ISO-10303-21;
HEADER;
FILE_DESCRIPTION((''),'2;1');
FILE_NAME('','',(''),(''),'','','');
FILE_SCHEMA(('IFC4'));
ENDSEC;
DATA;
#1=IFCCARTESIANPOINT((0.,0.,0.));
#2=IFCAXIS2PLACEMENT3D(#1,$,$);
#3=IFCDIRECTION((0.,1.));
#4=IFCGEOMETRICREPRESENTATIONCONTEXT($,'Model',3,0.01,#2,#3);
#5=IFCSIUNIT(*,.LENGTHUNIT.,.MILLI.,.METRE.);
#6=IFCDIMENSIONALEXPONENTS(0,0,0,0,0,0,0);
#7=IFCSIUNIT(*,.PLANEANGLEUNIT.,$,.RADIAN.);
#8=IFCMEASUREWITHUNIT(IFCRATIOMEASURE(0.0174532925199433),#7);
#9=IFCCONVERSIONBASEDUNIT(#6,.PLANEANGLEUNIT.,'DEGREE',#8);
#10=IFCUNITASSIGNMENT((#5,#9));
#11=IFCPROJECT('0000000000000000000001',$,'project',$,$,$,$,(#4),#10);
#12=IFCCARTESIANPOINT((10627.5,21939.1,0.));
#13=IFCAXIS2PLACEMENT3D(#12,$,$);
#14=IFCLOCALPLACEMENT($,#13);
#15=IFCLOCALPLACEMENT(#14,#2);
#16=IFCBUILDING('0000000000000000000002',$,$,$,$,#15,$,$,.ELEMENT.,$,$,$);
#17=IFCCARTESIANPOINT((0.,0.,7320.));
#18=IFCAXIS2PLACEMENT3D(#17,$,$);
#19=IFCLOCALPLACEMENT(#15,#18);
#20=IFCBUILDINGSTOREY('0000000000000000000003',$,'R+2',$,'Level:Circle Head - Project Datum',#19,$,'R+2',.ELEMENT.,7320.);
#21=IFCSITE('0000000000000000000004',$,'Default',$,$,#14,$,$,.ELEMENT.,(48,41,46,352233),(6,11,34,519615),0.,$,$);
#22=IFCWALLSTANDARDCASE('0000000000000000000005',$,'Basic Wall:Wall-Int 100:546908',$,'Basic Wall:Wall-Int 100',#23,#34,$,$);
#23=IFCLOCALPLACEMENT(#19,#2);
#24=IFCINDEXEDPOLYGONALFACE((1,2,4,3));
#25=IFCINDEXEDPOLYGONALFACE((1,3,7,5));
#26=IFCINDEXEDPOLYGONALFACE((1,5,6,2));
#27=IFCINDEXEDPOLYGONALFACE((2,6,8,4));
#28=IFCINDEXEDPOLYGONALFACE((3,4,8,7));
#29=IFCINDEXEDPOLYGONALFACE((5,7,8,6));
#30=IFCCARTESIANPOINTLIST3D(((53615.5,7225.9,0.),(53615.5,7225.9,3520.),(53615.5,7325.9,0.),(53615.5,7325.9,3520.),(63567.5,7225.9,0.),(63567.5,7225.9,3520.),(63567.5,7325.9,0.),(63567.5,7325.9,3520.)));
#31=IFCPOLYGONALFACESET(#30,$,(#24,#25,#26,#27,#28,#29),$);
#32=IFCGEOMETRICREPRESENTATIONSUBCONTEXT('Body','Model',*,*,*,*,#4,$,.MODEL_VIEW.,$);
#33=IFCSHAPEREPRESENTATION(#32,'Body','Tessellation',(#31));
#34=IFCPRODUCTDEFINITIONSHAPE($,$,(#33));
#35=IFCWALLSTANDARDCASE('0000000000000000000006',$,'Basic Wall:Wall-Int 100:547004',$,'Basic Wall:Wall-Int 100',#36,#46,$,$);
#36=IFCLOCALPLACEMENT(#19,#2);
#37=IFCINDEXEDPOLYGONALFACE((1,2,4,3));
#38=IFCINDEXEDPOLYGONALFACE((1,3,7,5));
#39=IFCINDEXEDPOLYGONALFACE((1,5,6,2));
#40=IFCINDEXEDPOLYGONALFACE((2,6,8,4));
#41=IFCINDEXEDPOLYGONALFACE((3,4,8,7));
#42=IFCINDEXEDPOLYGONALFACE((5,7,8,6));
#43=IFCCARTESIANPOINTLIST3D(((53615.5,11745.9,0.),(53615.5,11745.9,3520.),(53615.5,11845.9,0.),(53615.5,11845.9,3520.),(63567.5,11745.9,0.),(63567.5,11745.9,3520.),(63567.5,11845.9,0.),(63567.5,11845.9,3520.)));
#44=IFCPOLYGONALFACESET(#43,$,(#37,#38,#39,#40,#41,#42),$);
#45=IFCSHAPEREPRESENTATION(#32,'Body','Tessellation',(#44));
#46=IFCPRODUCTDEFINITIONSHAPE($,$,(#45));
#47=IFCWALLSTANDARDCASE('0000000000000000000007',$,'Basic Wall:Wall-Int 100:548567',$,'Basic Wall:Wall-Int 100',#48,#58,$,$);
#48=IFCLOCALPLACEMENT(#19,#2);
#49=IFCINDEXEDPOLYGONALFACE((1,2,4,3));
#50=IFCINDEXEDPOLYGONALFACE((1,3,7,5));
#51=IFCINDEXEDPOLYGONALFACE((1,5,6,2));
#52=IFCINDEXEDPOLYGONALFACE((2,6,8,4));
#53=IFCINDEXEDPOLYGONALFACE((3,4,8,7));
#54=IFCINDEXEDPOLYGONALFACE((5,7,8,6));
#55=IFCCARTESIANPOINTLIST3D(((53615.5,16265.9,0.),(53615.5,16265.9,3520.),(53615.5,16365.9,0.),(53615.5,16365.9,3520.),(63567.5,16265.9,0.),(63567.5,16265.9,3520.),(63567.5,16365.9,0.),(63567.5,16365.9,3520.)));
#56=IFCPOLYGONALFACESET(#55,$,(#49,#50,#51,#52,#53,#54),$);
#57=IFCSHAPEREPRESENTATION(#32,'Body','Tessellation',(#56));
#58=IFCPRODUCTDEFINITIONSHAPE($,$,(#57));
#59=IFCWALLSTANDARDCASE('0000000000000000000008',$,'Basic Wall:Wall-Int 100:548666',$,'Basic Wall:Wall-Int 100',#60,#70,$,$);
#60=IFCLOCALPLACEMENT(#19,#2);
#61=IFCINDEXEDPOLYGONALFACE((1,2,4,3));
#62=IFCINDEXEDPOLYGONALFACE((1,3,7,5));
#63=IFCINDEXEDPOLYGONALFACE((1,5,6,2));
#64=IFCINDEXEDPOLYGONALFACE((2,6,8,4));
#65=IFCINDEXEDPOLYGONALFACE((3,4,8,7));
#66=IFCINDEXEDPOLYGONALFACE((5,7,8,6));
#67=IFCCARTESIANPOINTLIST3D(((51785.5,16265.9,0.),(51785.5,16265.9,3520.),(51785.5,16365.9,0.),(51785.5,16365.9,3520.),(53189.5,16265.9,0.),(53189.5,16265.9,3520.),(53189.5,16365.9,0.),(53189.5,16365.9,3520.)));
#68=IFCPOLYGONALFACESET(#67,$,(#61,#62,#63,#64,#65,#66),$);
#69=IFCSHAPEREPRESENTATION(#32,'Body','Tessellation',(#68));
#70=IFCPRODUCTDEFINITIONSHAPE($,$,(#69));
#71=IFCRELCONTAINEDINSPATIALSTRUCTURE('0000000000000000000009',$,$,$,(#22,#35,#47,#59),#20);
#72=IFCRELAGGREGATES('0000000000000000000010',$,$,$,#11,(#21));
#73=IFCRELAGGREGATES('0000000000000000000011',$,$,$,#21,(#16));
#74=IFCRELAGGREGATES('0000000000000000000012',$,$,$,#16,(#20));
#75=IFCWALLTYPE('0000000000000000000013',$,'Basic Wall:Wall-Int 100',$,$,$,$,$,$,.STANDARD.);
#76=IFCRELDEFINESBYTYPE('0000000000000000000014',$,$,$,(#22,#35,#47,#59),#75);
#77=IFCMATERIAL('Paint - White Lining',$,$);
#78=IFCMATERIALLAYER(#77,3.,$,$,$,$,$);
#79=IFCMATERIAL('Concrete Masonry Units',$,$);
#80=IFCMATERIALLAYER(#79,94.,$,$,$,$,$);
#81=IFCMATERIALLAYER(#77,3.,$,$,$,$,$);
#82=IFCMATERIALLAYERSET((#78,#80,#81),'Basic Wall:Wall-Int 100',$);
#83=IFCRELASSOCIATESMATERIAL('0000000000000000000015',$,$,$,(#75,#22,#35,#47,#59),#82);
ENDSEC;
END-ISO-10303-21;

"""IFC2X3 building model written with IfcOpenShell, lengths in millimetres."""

from ifc_helpers import new_model, entity, si_unit, converted_unit, direction, frame, frame_2d, origin, place, context, subcontext, project, spatial, rectangle, extrude, material, layer, layer_set, layer_usage, type_object, element, save


model = new_model("IFC2X3")

# Units and contexts
model_context = context("Model", 3, precision=0.01, world=origin(), true_north=direction((0.0, 1.0)))
body_context = subcontext(model_context, "Body", "Model", "MODEL_VIEW")
ifc_project = project(units=[si_unit("LENGTHUNIT", "METRE", prefix="MILLI"), converted_unit("PLANEANGLEUNIT", "DEGREE", entity("IfcRatioMeasure", 0.0174532925199433), si_unit("PLANEANGLEUNIT", "RADIAN"), dimensions=[0, 0, 0, 0, 0, 0, 0])], contexts=[model_context])

# Site, building, storey
site_placement = place(None, frame((10627.5, 21939.1, 0.0)))
site = spatial("IfcSite", under=ifc_project, at=site_placement, Name="Default", CompositionType="ELEMENT", RefLatitude=(48, 41, 46, 352233), RefLongitude=(6, 11, 34, 519615), RefElevation=0.0)
building_placement = place(site_placement, origin())
building = spatial("IfcBuilding", under=site, at=building_placement, CompositionType="ELEMENT")
storey_placement = place(building_placement, frame((0.0, 0.0, 7320.0)))
storey = spatial("IfcBuildingStorey", under=building, at=storey_placement, Name="R+2", ObjectType="Level:Circle Head - Project Datum", LongName="R+2", CompositionType="ELEMENT", Elevation=7320.0)

# Walls
ifc_material_1 = material(Name="Paint - White Lining")
ifc_layer_1 = layer(ifc_material_1, 3.0)
ifc_material_2 = material(Name="Concrete Masonry Units")
ifc_layer_2 = layer(ifc_material_2, 94.0)
ifc_layer_3 = layer(ifc_material_1, 3.0)
ifc_layer_set = layer_set([ifc_layer_1, ifc_layer_2, ifc_layer_3], Name="Basic Wall:Wall-Int 100")
ifc_layer_usage_1 = layer_usage(ifc_layer_set, "AXIS2", "NEGATIVE", 50.0)
wall_type = type_object("IfcWallType", Name="Basic Wall:Wall-Int 100", PredefinedType="STANDARD", material=ifc_layer_set)
wall_1_placement = place(storey_placement, frame((63567.5, 7275.9, 0.0), z_axis=(0.0, 0.0, 1.0), x_axis=(-1.0, 0.0, 0.0)))
element("IfcWallStandardCase", 1, at=wall_1_placement, inside=storey, type_object=wall_type, material=ifc_layer_usage_1, Name="Basic Wall:Wall-Int 100:546908", ObjectType="Basic Wall:Wall-Int 100", context=body_context, shape_type="SweptSolid", body=[
    extrude(rectangle(XDim=9952.0, YDim=100.0, at=frame_2d((4976.0, 0.0), x_axis=(-1.0, 0.0))), origin(), (0.0, 0.0, 1.0), 3520.0),
])
ifc_layer_usage_2 = layer_usage(ifc_layer_set, "AXIS2", "NEGATIVE", 50.0)
wall_2_placement = place(storey_placement, frame((63567.5, 11795.9, 0.0), z_axis=(0.0, 0.0, 1.0), x_axis=(-1.0, 0.0, 0.0)))
element("IfcWallStandardCase", 2, at=wall_2_placement, inside=storey, type_object=wall_type, material=ifc_layer_usage_2, Name="Basic Wall:Wall-Int 100:547004", ObjectType="Basic Wall:Wall-Int 100", context=body_context, shape_type="SweptSolid", body=[
    extrude(rectangle(XDim=9952.0, YDim=100.0, at=frame_2d((4976.0, 0.0), x_axis=(-1.0, 0.0))), origin(), (0.0, 0.0, 1.0), 3520.0),
])
ifc_layer_usage_3 = layer_usage(ifc_layer_set, "AXIS2", "POSITIVE", -50.0)
wall_3_placement = place(storey_placement, frame((53615.5, 16315.9, 0.0)))
element("IfcWallStandardCase", 3, at=wall_3_placement, inside=storey, type_object=wall_type, material=ifc_layer_usage_3, Name="Basic Wall:Wall-Int 100:548567", ObjectType="Basic Wall:Wall-Int 100", context=body_context, shape_type="SweptSolid", body=[
    extrude(rectangle(XDim=9952.0, YDim=100.0, at=frame_2d((4976.0, 0.0), x_axis=(-1.0, 0.0))), origin(), (0.0, 0.0, 1.0), 3520.0),
])
ifc_layer_usage_4 = layer_usage(ifc_layer_set, "AXIS2", "NEGATIVE", 50.0)
wall_4_placement = place(storey_placement, frame((53189.5, 16315.9, 0.0), z_axis=(0.0, 0.0, 1.0), x_axis=(-1.0, 0.0, 0.0)))
element("IfcWallStandardCase", 4, at=wall_4_placement, inside=storey, type_object=wall_type, material=ifc_layer_usage_4, Name="Basic Wall:Wall-Int 100:548666", ObjectType="Basic Wall:Wall-Int 100", context=body_context, shape_type="SweptSolid", body=[
    extrude(rectangle(XDim=1404.0, YDim=100.0, at=frame_2d((702.0, 0.0), x_axis=(-1.0, 0.0))), origin(), (0.0, 0.0, 1.0), 3520.0),
])

save(model, "model.ifc")
